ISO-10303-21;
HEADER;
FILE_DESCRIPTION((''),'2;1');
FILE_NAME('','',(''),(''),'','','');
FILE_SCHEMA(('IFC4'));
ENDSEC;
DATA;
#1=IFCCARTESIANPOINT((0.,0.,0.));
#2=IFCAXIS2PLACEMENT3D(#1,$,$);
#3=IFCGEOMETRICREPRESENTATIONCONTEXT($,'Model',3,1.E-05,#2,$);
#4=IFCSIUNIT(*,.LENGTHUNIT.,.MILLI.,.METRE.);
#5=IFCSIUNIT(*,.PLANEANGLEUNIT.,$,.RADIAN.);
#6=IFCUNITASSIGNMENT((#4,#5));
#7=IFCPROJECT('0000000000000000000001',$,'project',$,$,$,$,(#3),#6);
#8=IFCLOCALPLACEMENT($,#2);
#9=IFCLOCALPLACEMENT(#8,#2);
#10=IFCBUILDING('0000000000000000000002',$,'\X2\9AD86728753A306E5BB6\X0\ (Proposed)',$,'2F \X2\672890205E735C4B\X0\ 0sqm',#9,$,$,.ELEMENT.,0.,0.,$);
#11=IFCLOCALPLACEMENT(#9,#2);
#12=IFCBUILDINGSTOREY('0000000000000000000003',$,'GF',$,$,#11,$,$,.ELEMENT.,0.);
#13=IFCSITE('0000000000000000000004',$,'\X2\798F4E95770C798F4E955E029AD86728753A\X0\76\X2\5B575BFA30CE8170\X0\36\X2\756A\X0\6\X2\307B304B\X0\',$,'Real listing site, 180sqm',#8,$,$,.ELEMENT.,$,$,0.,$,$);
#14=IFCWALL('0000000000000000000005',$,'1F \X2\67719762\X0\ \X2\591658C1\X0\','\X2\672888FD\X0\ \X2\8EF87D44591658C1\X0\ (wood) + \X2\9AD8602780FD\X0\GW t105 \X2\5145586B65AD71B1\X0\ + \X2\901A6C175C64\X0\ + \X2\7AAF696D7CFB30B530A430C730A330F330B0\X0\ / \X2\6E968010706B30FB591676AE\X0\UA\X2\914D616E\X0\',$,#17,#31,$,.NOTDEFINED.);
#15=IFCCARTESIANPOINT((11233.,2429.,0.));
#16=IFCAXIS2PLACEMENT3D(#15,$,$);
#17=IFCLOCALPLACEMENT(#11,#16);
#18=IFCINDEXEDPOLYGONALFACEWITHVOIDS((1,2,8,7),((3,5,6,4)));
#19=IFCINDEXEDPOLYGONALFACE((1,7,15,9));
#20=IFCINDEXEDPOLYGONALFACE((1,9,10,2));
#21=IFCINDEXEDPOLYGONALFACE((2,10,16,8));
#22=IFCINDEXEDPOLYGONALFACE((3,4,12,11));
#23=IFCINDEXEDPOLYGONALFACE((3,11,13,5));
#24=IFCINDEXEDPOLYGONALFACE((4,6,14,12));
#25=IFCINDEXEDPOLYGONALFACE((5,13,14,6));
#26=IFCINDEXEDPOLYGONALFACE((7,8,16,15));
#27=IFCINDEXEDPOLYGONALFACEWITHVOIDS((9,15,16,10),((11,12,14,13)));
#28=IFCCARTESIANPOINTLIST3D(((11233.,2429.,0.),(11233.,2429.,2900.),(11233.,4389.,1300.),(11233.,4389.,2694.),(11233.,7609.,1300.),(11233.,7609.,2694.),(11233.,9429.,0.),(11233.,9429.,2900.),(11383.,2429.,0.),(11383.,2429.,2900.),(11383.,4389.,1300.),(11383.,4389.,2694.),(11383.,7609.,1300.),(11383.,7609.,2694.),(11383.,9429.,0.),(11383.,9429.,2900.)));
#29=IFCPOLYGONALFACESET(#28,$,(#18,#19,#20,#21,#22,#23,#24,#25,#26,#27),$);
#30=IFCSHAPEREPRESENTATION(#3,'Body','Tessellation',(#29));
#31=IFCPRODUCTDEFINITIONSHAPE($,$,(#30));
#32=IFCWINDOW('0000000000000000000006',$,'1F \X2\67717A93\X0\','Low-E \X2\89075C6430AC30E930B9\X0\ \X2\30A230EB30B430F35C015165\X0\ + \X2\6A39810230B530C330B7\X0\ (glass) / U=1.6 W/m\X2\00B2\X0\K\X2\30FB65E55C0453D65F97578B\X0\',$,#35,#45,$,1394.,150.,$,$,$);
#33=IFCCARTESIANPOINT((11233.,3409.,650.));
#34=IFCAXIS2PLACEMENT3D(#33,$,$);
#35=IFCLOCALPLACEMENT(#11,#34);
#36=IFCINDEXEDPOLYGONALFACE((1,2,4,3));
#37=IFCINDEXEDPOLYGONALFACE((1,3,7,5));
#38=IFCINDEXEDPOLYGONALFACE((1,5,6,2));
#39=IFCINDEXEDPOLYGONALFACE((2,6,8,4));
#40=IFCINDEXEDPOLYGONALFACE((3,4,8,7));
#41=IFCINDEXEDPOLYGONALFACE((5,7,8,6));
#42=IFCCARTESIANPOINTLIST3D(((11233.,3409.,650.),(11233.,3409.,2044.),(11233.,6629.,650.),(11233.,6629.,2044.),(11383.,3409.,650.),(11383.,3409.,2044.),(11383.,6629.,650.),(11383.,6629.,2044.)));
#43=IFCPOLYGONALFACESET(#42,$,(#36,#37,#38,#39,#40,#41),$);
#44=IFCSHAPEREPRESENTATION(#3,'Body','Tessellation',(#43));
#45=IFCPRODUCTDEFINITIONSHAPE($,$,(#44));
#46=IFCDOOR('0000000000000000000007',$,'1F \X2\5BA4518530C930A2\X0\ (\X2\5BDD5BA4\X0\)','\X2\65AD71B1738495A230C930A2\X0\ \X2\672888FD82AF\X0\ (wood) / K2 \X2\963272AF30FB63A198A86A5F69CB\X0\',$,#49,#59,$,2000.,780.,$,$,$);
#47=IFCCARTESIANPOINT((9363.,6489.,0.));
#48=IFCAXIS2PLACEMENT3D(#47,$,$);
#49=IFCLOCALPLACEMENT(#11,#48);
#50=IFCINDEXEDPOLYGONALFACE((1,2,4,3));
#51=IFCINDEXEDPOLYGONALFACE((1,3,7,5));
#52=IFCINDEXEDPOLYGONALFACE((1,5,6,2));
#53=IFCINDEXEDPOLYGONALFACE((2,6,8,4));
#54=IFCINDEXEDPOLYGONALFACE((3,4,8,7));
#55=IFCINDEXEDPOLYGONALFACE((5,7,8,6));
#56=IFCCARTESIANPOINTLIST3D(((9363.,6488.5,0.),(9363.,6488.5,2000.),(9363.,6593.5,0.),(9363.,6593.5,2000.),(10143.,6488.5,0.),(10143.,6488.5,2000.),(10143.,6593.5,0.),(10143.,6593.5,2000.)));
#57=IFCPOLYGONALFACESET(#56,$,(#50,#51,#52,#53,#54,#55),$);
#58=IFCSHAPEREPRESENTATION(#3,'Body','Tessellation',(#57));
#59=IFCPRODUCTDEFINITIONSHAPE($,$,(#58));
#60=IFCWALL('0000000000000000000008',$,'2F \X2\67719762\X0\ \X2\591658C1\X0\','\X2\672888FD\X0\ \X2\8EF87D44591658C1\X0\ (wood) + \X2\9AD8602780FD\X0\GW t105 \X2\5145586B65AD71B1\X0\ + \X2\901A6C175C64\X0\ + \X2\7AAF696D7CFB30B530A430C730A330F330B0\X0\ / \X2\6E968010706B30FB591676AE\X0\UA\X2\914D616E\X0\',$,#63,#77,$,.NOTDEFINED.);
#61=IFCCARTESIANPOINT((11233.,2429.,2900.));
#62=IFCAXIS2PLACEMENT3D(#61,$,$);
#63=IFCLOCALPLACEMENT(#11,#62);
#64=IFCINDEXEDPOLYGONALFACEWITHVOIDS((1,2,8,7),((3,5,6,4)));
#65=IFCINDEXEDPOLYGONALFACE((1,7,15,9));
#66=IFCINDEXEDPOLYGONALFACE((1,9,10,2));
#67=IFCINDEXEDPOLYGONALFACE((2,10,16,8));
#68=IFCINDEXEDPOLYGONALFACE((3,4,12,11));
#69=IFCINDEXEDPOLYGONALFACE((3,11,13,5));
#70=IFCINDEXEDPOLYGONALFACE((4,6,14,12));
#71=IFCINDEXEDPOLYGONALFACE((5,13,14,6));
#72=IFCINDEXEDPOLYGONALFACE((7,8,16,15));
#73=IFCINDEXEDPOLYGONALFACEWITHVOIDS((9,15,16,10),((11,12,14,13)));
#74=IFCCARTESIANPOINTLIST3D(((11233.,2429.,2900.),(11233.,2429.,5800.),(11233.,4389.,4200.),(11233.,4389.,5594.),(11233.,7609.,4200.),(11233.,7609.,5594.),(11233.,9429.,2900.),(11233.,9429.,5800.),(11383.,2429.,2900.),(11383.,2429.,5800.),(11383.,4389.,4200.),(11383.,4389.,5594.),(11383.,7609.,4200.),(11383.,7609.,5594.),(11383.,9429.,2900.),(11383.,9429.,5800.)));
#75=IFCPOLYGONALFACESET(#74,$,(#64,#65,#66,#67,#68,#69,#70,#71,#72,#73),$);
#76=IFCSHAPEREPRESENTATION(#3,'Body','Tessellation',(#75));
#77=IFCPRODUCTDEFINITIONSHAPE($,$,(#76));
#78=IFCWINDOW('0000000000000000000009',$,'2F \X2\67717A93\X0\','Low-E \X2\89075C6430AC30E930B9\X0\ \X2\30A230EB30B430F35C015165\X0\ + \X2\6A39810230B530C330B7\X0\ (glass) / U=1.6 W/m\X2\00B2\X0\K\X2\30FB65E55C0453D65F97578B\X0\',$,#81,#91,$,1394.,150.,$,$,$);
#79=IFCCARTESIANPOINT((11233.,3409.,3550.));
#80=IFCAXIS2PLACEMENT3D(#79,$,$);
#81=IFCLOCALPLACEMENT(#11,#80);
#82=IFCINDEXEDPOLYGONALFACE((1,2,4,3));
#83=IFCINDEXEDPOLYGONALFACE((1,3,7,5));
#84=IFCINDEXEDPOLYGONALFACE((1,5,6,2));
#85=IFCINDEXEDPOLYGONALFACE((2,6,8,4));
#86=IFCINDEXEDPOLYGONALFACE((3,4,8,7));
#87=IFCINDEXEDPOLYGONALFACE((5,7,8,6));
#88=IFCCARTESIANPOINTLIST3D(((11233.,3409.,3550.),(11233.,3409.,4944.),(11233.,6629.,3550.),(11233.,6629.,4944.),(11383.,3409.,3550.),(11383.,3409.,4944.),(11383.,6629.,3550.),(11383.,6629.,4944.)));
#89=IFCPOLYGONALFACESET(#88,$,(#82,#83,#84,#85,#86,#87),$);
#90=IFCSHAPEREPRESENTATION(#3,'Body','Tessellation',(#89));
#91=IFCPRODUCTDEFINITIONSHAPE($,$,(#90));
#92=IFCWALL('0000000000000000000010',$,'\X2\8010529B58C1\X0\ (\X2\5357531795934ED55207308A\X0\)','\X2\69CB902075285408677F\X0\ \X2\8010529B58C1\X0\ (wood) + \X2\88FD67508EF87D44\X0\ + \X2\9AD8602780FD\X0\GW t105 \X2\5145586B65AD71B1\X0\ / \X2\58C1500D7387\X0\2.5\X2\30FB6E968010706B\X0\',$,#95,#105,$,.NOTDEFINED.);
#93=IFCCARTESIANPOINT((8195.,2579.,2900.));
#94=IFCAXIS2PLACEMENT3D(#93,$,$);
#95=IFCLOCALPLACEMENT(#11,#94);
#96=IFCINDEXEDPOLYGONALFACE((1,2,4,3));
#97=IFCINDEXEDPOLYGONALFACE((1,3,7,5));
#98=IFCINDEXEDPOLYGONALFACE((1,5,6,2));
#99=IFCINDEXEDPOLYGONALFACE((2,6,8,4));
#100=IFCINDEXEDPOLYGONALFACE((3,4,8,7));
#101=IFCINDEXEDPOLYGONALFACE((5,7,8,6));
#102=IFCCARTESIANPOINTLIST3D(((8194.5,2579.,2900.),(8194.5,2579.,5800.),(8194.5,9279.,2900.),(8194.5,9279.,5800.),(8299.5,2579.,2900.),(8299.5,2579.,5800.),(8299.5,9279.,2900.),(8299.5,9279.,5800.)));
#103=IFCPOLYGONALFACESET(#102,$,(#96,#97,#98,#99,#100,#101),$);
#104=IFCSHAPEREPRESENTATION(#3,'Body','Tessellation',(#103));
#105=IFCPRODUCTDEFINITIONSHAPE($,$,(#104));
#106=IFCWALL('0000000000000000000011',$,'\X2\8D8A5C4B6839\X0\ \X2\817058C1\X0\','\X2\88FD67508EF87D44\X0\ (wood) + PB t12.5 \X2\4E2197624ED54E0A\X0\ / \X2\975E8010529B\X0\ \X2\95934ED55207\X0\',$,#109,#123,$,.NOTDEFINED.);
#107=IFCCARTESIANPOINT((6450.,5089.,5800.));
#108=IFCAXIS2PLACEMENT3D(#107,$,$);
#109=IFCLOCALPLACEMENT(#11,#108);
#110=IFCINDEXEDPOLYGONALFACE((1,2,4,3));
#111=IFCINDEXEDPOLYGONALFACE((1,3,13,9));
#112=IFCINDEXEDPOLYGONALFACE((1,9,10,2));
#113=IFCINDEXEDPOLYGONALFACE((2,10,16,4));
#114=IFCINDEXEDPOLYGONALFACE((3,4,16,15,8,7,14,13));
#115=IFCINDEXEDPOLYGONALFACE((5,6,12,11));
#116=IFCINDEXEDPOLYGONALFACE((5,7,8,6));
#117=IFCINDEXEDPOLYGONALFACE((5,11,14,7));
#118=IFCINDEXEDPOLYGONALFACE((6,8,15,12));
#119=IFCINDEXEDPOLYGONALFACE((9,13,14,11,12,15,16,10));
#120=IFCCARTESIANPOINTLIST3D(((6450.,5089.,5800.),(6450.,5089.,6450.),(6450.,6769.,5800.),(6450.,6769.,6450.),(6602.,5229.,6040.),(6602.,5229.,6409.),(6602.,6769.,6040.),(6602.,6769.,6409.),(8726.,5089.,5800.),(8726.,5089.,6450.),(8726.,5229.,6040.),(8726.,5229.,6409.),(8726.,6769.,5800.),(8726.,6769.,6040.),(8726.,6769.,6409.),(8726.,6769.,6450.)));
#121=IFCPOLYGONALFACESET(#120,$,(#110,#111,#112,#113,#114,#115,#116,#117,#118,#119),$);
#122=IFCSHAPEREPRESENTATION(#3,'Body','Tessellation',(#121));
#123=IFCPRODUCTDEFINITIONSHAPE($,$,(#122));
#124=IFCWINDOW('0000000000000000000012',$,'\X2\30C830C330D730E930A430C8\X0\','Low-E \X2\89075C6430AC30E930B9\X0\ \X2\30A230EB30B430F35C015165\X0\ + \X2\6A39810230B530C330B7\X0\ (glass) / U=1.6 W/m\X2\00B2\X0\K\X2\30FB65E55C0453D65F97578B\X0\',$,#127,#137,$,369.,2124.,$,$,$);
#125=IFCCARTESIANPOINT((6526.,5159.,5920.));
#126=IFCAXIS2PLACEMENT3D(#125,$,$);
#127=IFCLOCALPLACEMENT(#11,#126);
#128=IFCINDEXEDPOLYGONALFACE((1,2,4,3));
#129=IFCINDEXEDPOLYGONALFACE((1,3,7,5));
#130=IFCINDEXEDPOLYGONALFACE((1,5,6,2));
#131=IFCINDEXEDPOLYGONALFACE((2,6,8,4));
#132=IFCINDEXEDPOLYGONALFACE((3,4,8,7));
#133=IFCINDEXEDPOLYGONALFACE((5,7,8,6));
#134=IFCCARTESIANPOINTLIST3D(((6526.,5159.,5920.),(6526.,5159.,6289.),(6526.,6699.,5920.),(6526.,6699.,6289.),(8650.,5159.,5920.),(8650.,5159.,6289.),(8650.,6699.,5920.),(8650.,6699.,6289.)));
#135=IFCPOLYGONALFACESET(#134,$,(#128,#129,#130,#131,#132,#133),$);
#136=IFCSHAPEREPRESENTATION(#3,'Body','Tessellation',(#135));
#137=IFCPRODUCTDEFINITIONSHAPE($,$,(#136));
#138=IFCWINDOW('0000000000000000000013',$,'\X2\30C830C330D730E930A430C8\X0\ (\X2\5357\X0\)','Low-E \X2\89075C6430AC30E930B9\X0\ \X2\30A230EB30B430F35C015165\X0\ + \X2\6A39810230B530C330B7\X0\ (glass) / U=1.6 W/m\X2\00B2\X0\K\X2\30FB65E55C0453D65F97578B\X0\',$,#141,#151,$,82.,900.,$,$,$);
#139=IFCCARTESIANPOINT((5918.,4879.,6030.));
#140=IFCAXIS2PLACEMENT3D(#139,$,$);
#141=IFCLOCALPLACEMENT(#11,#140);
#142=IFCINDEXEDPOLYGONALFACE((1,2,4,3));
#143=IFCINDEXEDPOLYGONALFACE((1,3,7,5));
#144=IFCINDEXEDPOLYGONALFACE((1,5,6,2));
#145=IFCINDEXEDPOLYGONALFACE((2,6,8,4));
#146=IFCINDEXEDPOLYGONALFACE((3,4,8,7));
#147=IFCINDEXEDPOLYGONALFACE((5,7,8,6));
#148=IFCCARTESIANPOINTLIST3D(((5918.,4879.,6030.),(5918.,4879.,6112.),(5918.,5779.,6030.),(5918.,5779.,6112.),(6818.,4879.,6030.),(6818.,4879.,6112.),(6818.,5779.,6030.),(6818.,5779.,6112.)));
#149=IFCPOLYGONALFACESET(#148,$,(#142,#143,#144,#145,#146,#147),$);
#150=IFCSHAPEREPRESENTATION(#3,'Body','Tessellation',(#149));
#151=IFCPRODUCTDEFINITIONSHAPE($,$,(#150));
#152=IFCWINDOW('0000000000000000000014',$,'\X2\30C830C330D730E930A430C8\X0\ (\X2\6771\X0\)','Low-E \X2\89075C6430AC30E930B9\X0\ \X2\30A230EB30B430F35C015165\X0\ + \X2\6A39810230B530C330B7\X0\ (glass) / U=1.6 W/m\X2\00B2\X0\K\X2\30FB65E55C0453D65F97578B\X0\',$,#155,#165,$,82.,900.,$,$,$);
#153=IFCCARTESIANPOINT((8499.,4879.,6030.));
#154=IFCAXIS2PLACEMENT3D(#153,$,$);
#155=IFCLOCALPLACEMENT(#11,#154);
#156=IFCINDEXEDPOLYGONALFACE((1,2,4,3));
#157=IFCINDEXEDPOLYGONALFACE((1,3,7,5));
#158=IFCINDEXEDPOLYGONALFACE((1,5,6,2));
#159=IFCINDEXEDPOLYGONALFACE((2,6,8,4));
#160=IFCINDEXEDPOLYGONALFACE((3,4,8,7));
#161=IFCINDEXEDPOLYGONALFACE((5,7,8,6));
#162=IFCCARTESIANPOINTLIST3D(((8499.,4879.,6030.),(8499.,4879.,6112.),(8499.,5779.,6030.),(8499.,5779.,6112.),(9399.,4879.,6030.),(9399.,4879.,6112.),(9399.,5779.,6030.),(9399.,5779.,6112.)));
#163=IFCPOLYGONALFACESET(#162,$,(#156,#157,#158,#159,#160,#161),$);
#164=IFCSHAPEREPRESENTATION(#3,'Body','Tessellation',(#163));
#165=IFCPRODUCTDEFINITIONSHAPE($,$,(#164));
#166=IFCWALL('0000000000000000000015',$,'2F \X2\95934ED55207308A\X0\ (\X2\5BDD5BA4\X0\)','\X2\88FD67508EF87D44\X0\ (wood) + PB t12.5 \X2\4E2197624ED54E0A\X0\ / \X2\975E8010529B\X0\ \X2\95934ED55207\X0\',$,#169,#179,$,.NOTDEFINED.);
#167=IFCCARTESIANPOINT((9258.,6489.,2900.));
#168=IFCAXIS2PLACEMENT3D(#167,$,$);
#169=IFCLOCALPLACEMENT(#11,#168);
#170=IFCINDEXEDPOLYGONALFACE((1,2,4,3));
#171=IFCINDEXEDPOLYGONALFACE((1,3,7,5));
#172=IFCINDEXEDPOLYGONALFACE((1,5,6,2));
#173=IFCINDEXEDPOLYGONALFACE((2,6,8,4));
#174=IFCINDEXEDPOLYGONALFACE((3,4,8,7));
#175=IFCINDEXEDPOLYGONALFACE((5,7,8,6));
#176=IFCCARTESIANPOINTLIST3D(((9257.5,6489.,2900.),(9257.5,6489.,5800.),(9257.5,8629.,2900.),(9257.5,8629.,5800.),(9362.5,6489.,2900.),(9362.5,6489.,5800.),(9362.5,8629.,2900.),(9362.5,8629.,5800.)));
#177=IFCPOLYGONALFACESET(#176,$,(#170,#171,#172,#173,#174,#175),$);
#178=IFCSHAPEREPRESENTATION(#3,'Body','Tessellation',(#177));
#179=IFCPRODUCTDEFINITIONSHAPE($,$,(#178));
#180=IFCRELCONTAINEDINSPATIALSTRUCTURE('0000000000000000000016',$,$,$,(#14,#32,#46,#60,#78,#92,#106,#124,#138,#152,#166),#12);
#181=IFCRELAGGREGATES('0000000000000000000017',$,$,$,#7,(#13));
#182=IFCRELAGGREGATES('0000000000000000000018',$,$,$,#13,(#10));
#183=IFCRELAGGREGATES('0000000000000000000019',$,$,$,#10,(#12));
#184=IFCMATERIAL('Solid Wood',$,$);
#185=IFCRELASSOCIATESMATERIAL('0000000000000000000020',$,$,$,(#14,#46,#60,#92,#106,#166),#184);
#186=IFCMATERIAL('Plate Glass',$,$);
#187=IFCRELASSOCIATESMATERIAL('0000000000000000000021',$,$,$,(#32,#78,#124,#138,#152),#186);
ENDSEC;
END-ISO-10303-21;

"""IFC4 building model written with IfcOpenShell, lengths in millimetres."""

from ifc_helpers import new_model, si_unit, frame, frame_2d, origin, place, context, project, spatial, rectangle, extrude, material, element, fill, save


model = new_model("IFC4")

# Units and contexts
model_context = context("Model", 3, precision=1e-05, world=origin())
ifc_project = project(units=[si_unit("LENGTHUNIT", "METRE", prefix="MILLI"), si_unit("PLANEANGLEUNIT", "RADIAN")], contexts=[model_context])

# Site, building, storey
site_placement = place(None, origin())
site = spatial("IfcSite", under=ifc_project, at=site_placement, Name="福井県福井市高木町76字寺ノ腰36番6ほか", ObjectType="Real listing site, 180sqm", CompositionType="ELEMENT", RefElevation=0.0)
building_placement = place(site_placement, origin())
building = spatial("IfcBuilding", under=site, at=building_placement, Name="高木町の家 (Proposed)", ObjectType="2F 木造平屋 0sqm", CompositionType="ELEMENT", ElevationOfRefHeight=0.0, ElevationOfTerrain=0.0)
storey_placement = place(building_placement, origin())
storey = spatial("IfcBuildingStorey", under=building, at=storey_placement, Name="GF", CompositionType="ELEMENT", Elevation=0.0)

# Wall, opening, window
ifc_material_1 = material(Name="Solid Wood")
wall_1_placement = place(storey_placement, frame((11233.0, 2429.0, 0.0)))
wall_1 = element("IfcWall", 1, at=wall_1_placement, inside=storey, material=ifc_material_1, Name="1F 東面 外壁", Description="木製 軸組外壁 (wood) + 高性能GW t105 充填断熱 + 通気層 + 窯業系サイディング / 準耐火・外皮UA配慮", PredefinedType="NOTDEFINED", context=model_context, shape_type="SweptSolid", body=[
    extrude(rectangle(XDim=150.0, YDim=7000.0, at=frame_2d((75.0, 3500.0))), frame((11233.0, 2429.0, 0.0)), (0.0, 0.0, 1.0), 2900.0),
])
opening_1_placement = place(storey_placement, frame((11233.0, 3409.0, 650.0)))
opening_1 = element("IfcOpeningElement", 2, at=opening_1_placement, cuts=wall_1, PredefinedType="NOTDEFINED", context=model_context, shape_type="SweptSolid", body=[
    extrude(rectangle(XDim=150.0, YDim=3220.0, at=frame_2d((75.0, 1610.0))), frame((11233.0, 3409.0, 650.0)), (0.0, 0.0, 1.0), 1394.0),
])
ifc_material_2 = material(Name="Plate Glass")
window_1_placement = place(storey_placement, frame((11233.0, 3409.0, 650.0)))
window_1 = element("IfcWindow", 3, at=window_1_placement, inside=storey, material=ifc_material_2, Name="1F 東窓", Description="Low-E 複層ガラス アルゴン封入 + 樹脂サッシ (glass) / U=1.6 W/m²K・日射取得型", OverallHeight=1394.0, OverallWidth=150.0, context=model_context, shape_type="SweptSolid", body=[
    extrude(rectangle(XDim=150.0, YDim=3220.0, at=frame_2d((75.0, 1610.0))), frame((11233.0, 3409.0, 650.0)), (0.0, 0.0, 1.0), 1394.0),
])
fill(opening_1, window_1)

# Door
door_1_placement = place(storey_placement, frame((9363.0, 6489.0, 0.0)))
element("IfcDoor", 4, at=door_1_placement, inside=storey, material=ifc_material_1, Name="1F 室内ドア (寝室)", Description="断熱玄関ドア 木製芯 (wood) / K2 防犯・採風機構", OverallHeight=2000.0, OverallWidth=780.0, context=model_context, shape_type="SweptSolid", body=[
    extrude(rectangle(XDim=780.0, YDim=105.0, at=frame_2d((390.0, 52.0))), frame((9363.0, 6489.0, 0.0)), (0.0, 0.0, 1.0), 2000.0),
])

# Wall, opening, window
wall_2_placement = place(storey_placement, frame((11233.0, 2429.0, 2900.0)))
wall_2 = element("IfcWall", 5, at=wall_2_placement, inside=storey, material=ifc_material_1, Name="2F 東面 外壁", Description="木製 軸組外壁 (wood) + 高性能GW t105 充填断熱 + 通気層 + 窯業系サイディング / 準耐火・外皮UA配慮", PredefinedType="NOTDEFINED", context=model_context, shape_type="SweptSolid", body=[
    extrude(rectangle(XDim=150.0, YDim=7000.0, at=frame_2d((75.0, 3500.0))), frame((11233.0, 2429.0, 2900.0)), (0.0, 0.0, 1.0), 2900.0),
])
opening_2_placement = place(storey_placement, frame((11233.0, 3409.0, 3550.0)))
opening_2 = element("IfcOpeningElement", 6, at=opening_2_placement, cuts=wall_2, PredefinedType="NOTDEFINED", context=model_context, shape_type="SweptSolid", body=[
    extrude(rectangle(XDim=150.0, YDim=3220.0, at=frame_2d((75.0, 1610.0))), frame((11233.0, 3409.0, 3550.0)), (0.0, 0.0, 1.0), 1394.0),
])
window_2_placement = place(storey_placement, frame((11233.0, 3409.0, 3550.0)))
window_2 = element("IfcWindow", 7, at=window_2_placement, inside=storey, material=ifc_material_2, Name="2F 東窓", Description="Low-E 複層ガラス アルゴン封入 + 樹脂サッシ (glass) / U=1.6 W/m²K・日射取得型", OverallHeight=1394.0, OverallWidth=150.0, context=model_context, shape_type="SweptSolid", body=[
    extrude(rectangle(XDim=150.0, YDim=3220.0, at=frame_2d((75.0, 1610.0))), frame((11233.0, 3409.0, 3550.0)), (0.0, 0.0, 1.0), 1394.0),
])
fill(opening_2, window_2)

# Wall
wall_3_placement = place(storey_placement, frame((8195.0, 2579.0, 2900.0)))
element("IfcWall", 8, at=wall_3_placement, inside=storey, material=ifc_material_1, Name="耐力壁 (南北間仕切り)", Description="構造用合板 耐力壁 (wood) + 製材軸組 + 高性能GW t105 充填断熱 / 壁倍率2.5・準耐火", PredefinedType="NOTDEFINED", context=model_context, shape_type="SweptSolid", body=[
    extrude(rectangle(XDim=105.0, YDim=6700.0, at=frame_2d((52.0, 3350.0))), frame((8195.0, 2579.0, 2900.0)), (0.0, 0.0, 1.0), 2900.0),
])

# Wall, openings, windows
wall_4_placement = place(storey_placement, frame((6450.0, 5089.0, 5800.0)))
wall_4 = element("IfcWall", 9, at=wall_4_placement, inside=storey, material=ifc_material_1, Name="越屋根 腰壁", Description="製材軸組 (wood) + PB t12.5 両面仕上 / 非耐力 間仕切", PredefinedType="NOTDEFINED", context=model_context, shape_type="SweptSolid", body=[
    extrude(rectangle(XDim=2276.0, YDim=1680.0, at=frame_2d((1138.0, 840.0))), frame((6450.0, 5089.0, 5800.0)), (0.0, 0.0, 1.0), 650.0),
])
opening_3_placement = place(storey_placement, frame((6526.0, 5159.0, 5920.0)))
opening_3 = element("IfcOpeningElement", 10, at=opening_3_placement, cuts=wall_4, PredefinedType="NOTDEFINED", context=model_context, shape_type="SweptSolid", body=[
    extrude(rectangle(XDim=2124.0, YDim=1540.0, at=frame_2d((1062.0, 770.0))), frame((6526.0, 5159.0, 5920.0)), (0.0, 0.0, 1.0), 369.0),
])
opening_4_placement = place(storey_placement, frame((5918.0, 4879.0, 6030.0)))
opening_4 = element("IfcOpeningElement", 11, at=opening_4_placement, cuts=wall_4, PredefinedType="NOTDEFINED", context=model_context, shape_type="SweptSolid", body=[
    extrude(rectangle(XDim=900.0, YDim=900.0, at=frame_2d((450.0, 450.0))), frame((5918.0, 4879.0, 6030.0)), (0.0, 0.0, 1.0), 82.0),
])
opening_5_placement = place(storey_placement, frame((8499.0, 4879.0, 6030.0)))
opening_5 = element("IfcOpeningElement", 12, at=opening_5_placement, cuts=wall_4, PredefinedType="NOTDEFINED", context=model_context, shape_type="SweptSolid", body=[
    extrude(rectangle(XDim=900.0, YDim=900.0, at=frame_2d((450.0, 450.0))), frame((8499.0, 4879.0, 6030.0)), (0.0, 0.0, 1.0), 82.0),
])
window_3_placement = place(storey_placement, frame((6526.0, 5159.0, 5920.0)))
window_3 = element("IfcWindow", 13, at=window_3_placement, inside=storey, material=ifc_material_2, Name="トップライト", Description="Low-E 複層ガラス アルゴン封入 + 樹脂サッシ (glass) / U=1.6 W/m²K・日射取得型", OverallHeight=369.0, OverallWidth=2124.0, context=model_context, shape_type="SweptSolid", body=[
    extrude(rectangle(XDim=2124.0, YDim=1540.0, at=frame_2d((1062.0, 770.0))), frame((6526.0, 5159.0, 5920.0)), (0.0, 0.0, 1.0), 369.0),
])
fill(opening_3, window_3)
window_4_placement = place(storey_placement, frame((5918.0, 4879.0, 6030.0)))
window_4 = element("IfcWindow", 14, at=window_4_placement, inside=storey, material=ifc_material_2, Name="トップライト (南)", Description="Low-E 複層ガラス アルゴン封入 + 樹脂サッシ (glass) / U=1.6 W/m²K・日射取得型", OverallHeight=82.0, OverallWidth=900.0, context=model_context, shape_type="SweptSolid", body=[
    extrude(rectangle(XDim=900.0, YDim=900.0, at=frame_2d((450.0, 450.0))), frame((5918.0, 4879.0, 6030.0)), (0.0, 0.0, 1.0), 82.0),
])
fill(opening_4, window_4)
window_5_placement = place(storey_placement, frame((8499.0, 4879.0, 6030.0)))
window_5 = element("IfcWindow", 15, at=window_5_placement, inside=storey, material=ifc_material_2, Name="トップライト (東)", Description="Low-E 複層ガラス アルゴン封入 + 樹脂サッシ (glass) / U=1.6 W/m²K・日射取得型", OverallHeight=82.0, OverallWidth=900.0, context=model_context, shape_type="SweptSolid", body=[
    extrude(rectangle(XDim=900.0, YDim=900.0, at=frame_2d((450.0, 450.0))), frame((8499.0, 4879.0, 6030.0)), (0.0, 0.0, 1.0), 82.0),
])
fill(opening_5, window_5)

# Wall
wall_5_placement = place(storey_placement, frame((9258.0, 6489.0, 2900.0)))
element("IfcWall", 16, at=wall_5_placement, inside=storey, material=ifc_material_1, Name="2F 間仕切り (寝室)", Description="製材軸組 (wood) + PB t12.5 両面仕上 / 非耐力 間仕切", PredefinedType="NOTDEFINED", context=model_context, shape_type="SweptSolid", body=[
    extrude(rectangle(XDim=105.0, YDim=2140.0, at=frame_2d((52.0, 1070.0))), frame((9258.0, 6489.0, 2900.0)), (0.0, 0.0, 1.0), 2900.0),
])

save(model, "model.ifc")
